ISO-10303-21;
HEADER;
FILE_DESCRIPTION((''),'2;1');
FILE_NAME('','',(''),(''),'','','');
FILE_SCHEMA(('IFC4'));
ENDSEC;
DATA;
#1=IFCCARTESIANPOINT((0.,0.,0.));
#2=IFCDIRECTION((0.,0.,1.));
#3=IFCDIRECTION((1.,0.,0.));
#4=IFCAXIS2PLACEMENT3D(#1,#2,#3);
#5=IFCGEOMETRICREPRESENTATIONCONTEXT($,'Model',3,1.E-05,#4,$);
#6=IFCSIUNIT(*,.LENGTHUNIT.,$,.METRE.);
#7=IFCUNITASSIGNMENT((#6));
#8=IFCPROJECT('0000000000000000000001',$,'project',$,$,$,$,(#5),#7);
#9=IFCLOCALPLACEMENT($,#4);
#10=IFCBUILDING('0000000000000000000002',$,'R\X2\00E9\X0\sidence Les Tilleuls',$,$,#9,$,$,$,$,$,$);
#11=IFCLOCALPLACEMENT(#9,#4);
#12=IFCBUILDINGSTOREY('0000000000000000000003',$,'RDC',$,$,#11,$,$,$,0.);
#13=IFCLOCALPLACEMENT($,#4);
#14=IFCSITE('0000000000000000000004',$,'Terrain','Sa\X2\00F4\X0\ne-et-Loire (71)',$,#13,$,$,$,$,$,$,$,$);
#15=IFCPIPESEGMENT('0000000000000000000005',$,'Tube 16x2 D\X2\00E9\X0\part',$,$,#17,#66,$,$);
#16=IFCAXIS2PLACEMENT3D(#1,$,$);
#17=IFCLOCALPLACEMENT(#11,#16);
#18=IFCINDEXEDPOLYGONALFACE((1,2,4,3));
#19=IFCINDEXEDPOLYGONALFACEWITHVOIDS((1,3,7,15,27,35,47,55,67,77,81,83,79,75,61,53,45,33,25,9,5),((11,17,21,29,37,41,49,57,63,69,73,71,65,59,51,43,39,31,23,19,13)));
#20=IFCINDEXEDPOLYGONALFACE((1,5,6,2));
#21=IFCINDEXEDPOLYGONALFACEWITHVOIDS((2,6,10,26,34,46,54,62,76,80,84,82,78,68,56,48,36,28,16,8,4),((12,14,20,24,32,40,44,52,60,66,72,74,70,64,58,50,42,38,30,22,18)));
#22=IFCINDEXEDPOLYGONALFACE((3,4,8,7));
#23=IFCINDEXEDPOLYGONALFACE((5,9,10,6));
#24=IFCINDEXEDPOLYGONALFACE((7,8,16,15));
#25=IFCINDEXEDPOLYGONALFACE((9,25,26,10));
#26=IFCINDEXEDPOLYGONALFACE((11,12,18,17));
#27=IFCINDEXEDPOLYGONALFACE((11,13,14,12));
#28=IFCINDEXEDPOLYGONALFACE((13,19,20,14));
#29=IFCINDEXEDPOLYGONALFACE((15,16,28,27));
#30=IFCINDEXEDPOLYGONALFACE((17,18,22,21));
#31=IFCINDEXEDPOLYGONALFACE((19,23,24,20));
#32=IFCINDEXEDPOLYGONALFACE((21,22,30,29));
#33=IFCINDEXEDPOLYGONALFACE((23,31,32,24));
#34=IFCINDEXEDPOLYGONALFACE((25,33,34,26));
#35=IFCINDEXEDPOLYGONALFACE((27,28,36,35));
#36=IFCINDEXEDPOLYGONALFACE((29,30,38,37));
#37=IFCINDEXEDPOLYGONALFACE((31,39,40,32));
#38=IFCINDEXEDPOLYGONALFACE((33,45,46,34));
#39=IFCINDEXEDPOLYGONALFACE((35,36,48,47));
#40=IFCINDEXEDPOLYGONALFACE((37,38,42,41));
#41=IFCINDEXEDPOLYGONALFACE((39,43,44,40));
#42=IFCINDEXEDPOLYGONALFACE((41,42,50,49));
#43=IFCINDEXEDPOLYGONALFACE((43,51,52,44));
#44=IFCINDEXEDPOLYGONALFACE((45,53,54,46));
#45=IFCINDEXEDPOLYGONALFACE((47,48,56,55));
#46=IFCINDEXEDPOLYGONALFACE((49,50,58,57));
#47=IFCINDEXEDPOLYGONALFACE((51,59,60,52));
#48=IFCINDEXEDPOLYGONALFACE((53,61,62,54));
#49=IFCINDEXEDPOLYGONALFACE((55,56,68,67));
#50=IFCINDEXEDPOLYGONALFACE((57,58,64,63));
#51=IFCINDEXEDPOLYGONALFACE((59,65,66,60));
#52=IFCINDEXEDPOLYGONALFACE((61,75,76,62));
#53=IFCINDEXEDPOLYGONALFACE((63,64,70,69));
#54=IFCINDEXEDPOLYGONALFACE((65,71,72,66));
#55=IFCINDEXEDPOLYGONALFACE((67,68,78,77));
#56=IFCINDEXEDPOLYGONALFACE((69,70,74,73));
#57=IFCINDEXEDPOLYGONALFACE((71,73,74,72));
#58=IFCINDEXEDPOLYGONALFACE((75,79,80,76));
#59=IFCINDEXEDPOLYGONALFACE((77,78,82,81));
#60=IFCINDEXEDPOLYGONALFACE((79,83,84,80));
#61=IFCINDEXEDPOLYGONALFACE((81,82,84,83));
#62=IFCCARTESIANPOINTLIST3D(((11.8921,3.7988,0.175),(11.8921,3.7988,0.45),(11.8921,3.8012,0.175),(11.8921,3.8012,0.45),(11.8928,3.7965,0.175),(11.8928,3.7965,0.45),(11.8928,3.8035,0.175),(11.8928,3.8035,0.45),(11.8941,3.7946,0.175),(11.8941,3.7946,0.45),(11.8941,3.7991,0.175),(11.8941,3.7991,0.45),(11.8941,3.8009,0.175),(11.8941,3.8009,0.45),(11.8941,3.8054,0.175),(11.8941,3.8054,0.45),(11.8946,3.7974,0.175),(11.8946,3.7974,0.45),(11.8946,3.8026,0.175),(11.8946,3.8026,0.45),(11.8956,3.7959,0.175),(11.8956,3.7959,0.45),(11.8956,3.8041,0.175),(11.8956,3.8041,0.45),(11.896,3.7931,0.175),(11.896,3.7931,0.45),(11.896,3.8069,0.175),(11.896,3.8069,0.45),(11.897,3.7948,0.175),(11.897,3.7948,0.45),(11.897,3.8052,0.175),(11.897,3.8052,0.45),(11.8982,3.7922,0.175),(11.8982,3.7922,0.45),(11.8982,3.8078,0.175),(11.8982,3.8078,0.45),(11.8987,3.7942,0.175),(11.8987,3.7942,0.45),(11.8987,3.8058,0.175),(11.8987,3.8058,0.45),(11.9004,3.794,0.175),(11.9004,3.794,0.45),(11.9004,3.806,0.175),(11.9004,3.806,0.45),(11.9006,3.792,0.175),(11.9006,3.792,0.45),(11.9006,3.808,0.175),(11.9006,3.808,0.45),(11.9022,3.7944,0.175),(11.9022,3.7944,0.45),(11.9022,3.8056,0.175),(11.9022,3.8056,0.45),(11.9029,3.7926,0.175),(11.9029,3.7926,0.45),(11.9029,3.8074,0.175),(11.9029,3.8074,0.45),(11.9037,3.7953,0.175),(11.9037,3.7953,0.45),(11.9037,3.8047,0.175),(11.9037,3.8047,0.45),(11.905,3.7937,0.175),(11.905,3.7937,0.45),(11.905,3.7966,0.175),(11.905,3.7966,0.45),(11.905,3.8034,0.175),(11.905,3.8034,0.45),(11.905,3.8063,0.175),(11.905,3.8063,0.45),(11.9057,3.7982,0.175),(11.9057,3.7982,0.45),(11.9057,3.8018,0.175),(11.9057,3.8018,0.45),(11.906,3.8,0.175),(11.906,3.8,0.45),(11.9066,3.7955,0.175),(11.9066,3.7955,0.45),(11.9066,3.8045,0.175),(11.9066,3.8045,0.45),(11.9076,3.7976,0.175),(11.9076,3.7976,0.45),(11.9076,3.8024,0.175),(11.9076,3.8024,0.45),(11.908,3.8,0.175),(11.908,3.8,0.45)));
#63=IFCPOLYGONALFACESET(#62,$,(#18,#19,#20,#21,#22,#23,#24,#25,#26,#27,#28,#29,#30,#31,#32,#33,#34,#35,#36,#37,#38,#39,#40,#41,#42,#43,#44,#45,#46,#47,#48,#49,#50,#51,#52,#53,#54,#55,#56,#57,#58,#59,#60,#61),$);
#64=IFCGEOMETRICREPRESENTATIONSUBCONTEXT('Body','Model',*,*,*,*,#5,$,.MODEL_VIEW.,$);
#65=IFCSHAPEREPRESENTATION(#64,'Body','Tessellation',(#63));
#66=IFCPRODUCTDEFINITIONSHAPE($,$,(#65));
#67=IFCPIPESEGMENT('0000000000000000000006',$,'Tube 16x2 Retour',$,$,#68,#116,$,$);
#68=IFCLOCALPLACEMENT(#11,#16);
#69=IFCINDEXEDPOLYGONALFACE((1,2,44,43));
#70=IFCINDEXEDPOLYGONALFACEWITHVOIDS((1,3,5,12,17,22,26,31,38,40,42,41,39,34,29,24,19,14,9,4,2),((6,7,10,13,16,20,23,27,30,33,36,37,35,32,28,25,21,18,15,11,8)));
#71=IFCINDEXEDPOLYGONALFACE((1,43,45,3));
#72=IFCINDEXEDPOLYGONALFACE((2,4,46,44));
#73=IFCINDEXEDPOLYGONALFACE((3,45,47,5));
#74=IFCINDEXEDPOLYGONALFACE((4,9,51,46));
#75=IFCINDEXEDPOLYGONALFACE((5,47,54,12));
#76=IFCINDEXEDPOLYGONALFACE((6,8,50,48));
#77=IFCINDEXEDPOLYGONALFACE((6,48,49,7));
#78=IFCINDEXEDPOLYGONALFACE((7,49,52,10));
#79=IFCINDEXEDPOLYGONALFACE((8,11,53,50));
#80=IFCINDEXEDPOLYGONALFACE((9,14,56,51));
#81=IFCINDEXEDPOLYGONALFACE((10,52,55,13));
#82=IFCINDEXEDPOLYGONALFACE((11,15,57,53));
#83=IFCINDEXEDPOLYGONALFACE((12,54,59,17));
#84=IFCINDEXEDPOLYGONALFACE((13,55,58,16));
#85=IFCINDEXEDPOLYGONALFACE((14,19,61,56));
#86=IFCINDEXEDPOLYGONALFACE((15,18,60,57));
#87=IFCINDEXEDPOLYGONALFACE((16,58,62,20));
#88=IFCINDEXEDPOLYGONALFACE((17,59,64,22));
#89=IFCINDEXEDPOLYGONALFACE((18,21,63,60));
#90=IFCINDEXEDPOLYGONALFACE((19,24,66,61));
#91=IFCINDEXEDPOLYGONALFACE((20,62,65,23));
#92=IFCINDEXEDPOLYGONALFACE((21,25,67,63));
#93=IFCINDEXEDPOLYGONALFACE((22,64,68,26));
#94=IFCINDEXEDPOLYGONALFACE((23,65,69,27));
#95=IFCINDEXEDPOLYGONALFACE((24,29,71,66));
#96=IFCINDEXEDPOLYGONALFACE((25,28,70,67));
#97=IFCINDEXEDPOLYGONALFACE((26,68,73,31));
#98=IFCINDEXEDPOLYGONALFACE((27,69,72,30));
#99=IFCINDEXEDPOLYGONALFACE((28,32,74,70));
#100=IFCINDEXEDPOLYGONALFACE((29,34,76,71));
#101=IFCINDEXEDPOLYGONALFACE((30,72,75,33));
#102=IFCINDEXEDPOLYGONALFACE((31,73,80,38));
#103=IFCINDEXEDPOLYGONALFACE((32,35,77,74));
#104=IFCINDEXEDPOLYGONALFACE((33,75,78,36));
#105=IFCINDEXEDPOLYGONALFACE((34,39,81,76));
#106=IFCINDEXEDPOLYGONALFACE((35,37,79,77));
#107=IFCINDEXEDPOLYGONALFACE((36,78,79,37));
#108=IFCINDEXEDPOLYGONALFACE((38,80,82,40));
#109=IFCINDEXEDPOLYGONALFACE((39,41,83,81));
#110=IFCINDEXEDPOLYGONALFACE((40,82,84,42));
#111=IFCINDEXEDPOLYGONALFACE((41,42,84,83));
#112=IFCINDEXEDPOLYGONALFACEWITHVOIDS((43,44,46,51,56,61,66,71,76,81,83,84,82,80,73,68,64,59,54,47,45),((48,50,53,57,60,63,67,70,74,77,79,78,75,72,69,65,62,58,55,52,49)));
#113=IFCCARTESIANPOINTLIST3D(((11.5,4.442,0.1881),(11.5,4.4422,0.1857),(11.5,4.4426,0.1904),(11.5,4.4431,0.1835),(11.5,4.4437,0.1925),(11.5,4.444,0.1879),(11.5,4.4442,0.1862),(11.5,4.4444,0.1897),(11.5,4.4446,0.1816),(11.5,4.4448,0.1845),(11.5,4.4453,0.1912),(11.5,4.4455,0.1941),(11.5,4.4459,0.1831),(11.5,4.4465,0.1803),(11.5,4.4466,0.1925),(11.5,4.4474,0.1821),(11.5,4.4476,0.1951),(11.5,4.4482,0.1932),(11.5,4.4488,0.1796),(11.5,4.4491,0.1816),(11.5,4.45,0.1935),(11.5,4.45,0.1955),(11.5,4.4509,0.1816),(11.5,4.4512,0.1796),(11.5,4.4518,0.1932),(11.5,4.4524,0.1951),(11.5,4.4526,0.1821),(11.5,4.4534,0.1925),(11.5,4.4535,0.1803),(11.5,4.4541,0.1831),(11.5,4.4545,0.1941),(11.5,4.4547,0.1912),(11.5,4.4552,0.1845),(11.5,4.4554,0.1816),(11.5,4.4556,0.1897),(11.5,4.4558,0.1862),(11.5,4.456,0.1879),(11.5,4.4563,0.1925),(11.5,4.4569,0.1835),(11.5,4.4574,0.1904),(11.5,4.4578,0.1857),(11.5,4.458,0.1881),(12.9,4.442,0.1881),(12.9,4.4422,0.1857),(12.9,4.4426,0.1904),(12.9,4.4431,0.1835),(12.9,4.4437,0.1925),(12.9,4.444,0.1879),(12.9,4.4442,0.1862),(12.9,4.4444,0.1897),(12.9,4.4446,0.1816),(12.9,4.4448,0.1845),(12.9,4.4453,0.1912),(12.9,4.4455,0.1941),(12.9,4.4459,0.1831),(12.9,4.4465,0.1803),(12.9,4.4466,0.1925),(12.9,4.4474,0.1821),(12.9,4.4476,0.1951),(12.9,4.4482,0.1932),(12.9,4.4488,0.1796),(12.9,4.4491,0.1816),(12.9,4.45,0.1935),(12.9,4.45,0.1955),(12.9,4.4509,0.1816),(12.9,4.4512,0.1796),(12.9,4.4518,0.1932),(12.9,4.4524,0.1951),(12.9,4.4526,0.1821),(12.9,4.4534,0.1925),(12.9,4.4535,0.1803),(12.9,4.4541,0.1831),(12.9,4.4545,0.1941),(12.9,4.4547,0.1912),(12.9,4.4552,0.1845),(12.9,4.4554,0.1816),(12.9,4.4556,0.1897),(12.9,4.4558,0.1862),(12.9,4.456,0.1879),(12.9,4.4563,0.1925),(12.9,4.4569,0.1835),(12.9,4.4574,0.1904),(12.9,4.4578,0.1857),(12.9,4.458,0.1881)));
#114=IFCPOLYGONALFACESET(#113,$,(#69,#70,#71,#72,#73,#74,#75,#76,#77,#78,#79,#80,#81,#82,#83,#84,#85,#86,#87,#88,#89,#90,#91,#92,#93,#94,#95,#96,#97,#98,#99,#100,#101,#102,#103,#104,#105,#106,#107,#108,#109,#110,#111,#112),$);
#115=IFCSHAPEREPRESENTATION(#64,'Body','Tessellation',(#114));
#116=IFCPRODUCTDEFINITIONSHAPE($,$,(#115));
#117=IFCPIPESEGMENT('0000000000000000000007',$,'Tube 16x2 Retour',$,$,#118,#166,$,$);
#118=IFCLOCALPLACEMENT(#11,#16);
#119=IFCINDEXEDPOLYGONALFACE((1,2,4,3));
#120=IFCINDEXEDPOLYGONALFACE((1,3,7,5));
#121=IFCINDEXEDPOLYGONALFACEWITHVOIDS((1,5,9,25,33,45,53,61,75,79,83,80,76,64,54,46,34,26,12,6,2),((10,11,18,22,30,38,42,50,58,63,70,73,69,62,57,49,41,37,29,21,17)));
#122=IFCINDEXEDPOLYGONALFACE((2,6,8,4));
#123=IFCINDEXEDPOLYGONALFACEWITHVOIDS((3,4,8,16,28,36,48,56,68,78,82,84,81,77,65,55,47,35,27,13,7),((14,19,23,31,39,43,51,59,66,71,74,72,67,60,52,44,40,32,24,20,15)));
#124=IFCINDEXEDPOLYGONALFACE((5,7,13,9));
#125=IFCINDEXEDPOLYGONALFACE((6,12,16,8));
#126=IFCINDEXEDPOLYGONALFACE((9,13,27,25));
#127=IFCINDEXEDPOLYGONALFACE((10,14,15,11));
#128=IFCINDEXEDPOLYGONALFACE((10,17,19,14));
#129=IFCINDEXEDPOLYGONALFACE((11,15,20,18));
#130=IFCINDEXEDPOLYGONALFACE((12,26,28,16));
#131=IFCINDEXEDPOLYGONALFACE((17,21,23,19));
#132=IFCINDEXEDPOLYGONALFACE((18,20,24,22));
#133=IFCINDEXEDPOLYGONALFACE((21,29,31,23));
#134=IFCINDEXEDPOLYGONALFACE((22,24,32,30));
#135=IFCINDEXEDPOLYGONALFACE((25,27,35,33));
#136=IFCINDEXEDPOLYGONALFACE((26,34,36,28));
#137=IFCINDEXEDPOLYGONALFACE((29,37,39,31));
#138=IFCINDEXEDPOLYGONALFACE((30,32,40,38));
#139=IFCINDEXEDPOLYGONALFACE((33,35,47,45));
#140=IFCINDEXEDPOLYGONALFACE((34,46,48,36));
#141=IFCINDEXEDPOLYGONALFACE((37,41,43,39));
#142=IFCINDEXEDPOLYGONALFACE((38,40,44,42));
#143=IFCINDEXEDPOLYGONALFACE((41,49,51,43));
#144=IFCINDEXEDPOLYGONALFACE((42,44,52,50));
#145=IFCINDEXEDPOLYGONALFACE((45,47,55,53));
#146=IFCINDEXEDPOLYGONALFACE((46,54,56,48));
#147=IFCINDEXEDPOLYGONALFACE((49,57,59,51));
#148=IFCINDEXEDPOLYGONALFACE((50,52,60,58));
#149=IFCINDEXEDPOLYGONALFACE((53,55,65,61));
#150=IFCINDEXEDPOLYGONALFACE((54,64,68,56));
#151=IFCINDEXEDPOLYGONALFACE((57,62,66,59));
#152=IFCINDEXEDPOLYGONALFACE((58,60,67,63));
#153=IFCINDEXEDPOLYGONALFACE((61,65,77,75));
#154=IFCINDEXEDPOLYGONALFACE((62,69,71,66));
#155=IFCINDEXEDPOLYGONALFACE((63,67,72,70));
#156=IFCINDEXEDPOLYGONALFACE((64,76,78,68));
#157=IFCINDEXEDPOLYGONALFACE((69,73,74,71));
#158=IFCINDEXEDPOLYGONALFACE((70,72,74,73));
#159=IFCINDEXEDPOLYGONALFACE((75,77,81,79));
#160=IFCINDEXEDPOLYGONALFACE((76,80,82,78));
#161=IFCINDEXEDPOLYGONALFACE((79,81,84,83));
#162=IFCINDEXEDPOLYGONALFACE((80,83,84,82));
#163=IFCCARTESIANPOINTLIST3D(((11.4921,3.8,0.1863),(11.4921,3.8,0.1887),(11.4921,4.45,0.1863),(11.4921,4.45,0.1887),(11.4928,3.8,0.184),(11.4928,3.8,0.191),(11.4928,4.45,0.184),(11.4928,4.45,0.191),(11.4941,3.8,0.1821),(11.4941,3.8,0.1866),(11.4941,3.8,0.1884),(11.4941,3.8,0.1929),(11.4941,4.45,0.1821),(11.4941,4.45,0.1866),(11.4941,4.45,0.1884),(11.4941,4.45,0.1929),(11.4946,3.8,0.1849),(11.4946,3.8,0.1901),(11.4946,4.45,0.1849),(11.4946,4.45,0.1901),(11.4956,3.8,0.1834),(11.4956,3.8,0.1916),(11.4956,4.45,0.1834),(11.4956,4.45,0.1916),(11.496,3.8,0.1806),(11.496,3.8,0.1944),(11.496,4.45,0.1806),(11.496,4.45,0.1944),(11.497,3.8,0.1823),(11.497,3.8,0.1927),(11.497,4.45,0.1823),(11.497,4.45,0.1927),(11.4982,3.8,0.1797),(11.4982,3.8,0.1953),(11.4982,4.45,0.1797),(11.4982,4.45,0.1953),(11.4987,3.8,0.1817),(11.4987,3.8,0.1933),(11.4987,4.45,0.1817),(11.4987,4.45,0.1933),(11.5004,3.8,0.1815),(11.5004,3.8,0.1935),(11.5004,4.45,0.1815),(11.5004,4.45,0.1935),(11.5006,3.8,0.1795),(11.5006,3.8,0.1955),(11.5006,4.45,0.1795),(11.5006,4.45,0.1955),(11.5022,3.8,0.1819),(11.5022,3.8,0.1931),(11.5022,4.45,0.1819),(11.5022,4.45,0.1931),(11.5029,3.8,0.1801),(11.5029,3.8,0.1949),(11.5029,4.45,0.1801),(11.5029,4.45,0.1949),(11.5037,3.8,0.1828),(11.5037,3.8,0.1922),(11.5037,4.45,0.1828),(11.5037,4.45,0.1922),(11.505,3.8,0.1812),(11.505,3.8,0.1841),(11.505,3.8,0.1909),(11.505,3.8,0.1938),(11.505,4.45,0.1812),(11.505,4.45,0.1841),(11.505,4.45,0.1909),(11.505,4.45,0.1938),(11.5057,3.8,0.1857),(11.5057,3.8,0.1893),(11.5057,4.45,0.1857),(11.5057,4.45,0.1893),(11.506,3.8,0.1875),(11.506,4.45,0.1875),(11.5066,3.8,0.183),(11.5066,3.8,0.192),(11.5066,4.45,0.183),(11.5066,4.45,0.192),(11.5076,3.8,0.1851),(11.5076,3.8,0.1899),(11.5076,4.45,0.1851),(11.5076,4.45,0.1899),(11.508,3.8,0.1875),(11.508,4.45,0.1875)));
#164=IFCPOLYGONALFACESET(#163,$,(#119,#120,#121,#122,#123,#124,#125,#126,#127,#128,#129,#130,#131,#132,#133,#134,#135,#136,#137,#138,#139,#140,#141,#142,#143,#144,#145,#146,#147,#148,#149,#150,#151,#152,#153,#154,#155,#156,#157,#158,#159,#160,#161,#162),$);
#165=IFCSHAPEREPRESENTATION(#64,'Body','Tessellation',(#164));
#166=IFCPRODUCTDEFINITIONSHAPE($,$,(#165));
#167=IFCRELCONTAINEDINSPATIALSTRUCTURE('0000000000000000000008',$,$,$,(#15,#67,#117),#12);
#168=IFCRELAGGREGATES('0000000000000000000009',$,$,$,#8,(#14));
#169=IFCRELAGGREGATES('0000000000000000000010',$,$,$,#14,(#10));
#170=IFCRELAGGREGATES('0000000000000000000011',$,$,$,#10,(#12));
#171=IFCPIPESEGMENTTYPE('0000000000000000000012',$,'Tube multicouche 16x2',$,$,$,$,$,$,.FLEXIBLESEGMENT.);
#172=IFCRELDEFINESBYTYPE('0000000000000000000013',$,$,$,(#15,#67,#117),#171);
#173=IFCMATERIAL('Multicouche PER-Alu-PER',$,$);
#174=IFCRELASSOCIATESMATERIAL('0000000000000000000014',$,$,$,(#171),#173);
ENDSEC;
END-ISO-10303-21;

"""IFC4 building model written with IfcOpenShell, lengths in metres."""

from ifc_helpers import new_model, si_unit, frame, origin_with_axes, place, context, subcontext, project, spatial, hollow_circle, extrude, material, type_object, element, save


model = new_model("IFC4")

# Units and contexts
model_context = context("Model", 3, precision=1e-05, world=origin_with_axes())
body_context = subcontext(model_context, "Body", "Model", "MODEL_VIEW")
ifc_project = project(units=[si_unit("LENGTHUNIT", "METRE")], contexts=[model_context])

# Site, building, storey
site_placement = place(None, origin_with_axes())
site = spatial("IfcSite", under=ifc_project, at=site_placement, Name="Terrain", Description="Saône-et-Loire (71)")
building_placement = place(None, origin_with_axes())
building = spatial("IfcBuilding", under=site, at=building_placement, Name="Résidence Les Tilleuls")
storey_placement = place(building_placement, origin_with_axes())
storey = spatial("IfcBuildingStorey", under=building, at=storey_placement, Name="RDC", Elevation=0.0)

# Pipe segments
ifc_material = material(Name="Multicouche PER-Alu-PER")
pipe_segment_type_1 = type_object("IfcPipeSegmentType", Name="Tube multicouche 16x2", PredefinedType="FLEXIBLESEGMENT", material=ifc_material)
pipe_segment_1_placement = place(storey_placement, frame((11.9, 3.8, 0.175), z_axis=(0.0, 0.0, 1.0), x_axis=(1.0, 0.0, 0.0)))
element("IfcPipeSegment", 1, at=pipe_segment_1_placement, inside=storey, type_object=pipe_segment_type_1, Name="Tube 16x2 Départ", context=body_context, shape_type="SweptSolid", body=[
    extrude(hollow_circle(Radius=0.008, WallThickness=0.002), origin_with_axes(), (0.0, 0.0, 1.0), 0.275),
])
pipe_segment_2_placement = place(storey_placement, frame((12.9, 4.45, 0.1875), z_axis=(-1.0, 0.0, 0.0), x_axis=(0.0, 0.0, 1.0)))
element("IfcPipeSegment", 2, at=pipe_segment_2_placement, inside=storey, type_object=pipe_segment_type_1, Name="Tube 16x2 Retour", context=body_context, shape_type="SweptSolid", body=[
    extrude(hollow_circle(Radius=0.008, WallThickness=0.002), origin_with_axes(), (0.0, 0.0, 1.0), 1.4),
])
pipe_segment_3_placement = place(storey_placement, frame((11.5, 4.45, 0.1875), z_axis=(0.0, -1.0, 0.0), x_axis=(1.0, 0.0, 0.0)))
element("IfcPipeSegment", 3, at=pipe_segment_3_placement, inside=storey, type_object=pipe_segment_type_1, Name="Tube 16x2 Retour", context=body_context, shape_type="SweptSolid", body=[
    extrude(hollow_circle(Radius=0.008, WallThickness=0.002), origin_with_axes(), (0.0, 0.0, 1.0), 0.65),
])

save(model, "model.ifc")
